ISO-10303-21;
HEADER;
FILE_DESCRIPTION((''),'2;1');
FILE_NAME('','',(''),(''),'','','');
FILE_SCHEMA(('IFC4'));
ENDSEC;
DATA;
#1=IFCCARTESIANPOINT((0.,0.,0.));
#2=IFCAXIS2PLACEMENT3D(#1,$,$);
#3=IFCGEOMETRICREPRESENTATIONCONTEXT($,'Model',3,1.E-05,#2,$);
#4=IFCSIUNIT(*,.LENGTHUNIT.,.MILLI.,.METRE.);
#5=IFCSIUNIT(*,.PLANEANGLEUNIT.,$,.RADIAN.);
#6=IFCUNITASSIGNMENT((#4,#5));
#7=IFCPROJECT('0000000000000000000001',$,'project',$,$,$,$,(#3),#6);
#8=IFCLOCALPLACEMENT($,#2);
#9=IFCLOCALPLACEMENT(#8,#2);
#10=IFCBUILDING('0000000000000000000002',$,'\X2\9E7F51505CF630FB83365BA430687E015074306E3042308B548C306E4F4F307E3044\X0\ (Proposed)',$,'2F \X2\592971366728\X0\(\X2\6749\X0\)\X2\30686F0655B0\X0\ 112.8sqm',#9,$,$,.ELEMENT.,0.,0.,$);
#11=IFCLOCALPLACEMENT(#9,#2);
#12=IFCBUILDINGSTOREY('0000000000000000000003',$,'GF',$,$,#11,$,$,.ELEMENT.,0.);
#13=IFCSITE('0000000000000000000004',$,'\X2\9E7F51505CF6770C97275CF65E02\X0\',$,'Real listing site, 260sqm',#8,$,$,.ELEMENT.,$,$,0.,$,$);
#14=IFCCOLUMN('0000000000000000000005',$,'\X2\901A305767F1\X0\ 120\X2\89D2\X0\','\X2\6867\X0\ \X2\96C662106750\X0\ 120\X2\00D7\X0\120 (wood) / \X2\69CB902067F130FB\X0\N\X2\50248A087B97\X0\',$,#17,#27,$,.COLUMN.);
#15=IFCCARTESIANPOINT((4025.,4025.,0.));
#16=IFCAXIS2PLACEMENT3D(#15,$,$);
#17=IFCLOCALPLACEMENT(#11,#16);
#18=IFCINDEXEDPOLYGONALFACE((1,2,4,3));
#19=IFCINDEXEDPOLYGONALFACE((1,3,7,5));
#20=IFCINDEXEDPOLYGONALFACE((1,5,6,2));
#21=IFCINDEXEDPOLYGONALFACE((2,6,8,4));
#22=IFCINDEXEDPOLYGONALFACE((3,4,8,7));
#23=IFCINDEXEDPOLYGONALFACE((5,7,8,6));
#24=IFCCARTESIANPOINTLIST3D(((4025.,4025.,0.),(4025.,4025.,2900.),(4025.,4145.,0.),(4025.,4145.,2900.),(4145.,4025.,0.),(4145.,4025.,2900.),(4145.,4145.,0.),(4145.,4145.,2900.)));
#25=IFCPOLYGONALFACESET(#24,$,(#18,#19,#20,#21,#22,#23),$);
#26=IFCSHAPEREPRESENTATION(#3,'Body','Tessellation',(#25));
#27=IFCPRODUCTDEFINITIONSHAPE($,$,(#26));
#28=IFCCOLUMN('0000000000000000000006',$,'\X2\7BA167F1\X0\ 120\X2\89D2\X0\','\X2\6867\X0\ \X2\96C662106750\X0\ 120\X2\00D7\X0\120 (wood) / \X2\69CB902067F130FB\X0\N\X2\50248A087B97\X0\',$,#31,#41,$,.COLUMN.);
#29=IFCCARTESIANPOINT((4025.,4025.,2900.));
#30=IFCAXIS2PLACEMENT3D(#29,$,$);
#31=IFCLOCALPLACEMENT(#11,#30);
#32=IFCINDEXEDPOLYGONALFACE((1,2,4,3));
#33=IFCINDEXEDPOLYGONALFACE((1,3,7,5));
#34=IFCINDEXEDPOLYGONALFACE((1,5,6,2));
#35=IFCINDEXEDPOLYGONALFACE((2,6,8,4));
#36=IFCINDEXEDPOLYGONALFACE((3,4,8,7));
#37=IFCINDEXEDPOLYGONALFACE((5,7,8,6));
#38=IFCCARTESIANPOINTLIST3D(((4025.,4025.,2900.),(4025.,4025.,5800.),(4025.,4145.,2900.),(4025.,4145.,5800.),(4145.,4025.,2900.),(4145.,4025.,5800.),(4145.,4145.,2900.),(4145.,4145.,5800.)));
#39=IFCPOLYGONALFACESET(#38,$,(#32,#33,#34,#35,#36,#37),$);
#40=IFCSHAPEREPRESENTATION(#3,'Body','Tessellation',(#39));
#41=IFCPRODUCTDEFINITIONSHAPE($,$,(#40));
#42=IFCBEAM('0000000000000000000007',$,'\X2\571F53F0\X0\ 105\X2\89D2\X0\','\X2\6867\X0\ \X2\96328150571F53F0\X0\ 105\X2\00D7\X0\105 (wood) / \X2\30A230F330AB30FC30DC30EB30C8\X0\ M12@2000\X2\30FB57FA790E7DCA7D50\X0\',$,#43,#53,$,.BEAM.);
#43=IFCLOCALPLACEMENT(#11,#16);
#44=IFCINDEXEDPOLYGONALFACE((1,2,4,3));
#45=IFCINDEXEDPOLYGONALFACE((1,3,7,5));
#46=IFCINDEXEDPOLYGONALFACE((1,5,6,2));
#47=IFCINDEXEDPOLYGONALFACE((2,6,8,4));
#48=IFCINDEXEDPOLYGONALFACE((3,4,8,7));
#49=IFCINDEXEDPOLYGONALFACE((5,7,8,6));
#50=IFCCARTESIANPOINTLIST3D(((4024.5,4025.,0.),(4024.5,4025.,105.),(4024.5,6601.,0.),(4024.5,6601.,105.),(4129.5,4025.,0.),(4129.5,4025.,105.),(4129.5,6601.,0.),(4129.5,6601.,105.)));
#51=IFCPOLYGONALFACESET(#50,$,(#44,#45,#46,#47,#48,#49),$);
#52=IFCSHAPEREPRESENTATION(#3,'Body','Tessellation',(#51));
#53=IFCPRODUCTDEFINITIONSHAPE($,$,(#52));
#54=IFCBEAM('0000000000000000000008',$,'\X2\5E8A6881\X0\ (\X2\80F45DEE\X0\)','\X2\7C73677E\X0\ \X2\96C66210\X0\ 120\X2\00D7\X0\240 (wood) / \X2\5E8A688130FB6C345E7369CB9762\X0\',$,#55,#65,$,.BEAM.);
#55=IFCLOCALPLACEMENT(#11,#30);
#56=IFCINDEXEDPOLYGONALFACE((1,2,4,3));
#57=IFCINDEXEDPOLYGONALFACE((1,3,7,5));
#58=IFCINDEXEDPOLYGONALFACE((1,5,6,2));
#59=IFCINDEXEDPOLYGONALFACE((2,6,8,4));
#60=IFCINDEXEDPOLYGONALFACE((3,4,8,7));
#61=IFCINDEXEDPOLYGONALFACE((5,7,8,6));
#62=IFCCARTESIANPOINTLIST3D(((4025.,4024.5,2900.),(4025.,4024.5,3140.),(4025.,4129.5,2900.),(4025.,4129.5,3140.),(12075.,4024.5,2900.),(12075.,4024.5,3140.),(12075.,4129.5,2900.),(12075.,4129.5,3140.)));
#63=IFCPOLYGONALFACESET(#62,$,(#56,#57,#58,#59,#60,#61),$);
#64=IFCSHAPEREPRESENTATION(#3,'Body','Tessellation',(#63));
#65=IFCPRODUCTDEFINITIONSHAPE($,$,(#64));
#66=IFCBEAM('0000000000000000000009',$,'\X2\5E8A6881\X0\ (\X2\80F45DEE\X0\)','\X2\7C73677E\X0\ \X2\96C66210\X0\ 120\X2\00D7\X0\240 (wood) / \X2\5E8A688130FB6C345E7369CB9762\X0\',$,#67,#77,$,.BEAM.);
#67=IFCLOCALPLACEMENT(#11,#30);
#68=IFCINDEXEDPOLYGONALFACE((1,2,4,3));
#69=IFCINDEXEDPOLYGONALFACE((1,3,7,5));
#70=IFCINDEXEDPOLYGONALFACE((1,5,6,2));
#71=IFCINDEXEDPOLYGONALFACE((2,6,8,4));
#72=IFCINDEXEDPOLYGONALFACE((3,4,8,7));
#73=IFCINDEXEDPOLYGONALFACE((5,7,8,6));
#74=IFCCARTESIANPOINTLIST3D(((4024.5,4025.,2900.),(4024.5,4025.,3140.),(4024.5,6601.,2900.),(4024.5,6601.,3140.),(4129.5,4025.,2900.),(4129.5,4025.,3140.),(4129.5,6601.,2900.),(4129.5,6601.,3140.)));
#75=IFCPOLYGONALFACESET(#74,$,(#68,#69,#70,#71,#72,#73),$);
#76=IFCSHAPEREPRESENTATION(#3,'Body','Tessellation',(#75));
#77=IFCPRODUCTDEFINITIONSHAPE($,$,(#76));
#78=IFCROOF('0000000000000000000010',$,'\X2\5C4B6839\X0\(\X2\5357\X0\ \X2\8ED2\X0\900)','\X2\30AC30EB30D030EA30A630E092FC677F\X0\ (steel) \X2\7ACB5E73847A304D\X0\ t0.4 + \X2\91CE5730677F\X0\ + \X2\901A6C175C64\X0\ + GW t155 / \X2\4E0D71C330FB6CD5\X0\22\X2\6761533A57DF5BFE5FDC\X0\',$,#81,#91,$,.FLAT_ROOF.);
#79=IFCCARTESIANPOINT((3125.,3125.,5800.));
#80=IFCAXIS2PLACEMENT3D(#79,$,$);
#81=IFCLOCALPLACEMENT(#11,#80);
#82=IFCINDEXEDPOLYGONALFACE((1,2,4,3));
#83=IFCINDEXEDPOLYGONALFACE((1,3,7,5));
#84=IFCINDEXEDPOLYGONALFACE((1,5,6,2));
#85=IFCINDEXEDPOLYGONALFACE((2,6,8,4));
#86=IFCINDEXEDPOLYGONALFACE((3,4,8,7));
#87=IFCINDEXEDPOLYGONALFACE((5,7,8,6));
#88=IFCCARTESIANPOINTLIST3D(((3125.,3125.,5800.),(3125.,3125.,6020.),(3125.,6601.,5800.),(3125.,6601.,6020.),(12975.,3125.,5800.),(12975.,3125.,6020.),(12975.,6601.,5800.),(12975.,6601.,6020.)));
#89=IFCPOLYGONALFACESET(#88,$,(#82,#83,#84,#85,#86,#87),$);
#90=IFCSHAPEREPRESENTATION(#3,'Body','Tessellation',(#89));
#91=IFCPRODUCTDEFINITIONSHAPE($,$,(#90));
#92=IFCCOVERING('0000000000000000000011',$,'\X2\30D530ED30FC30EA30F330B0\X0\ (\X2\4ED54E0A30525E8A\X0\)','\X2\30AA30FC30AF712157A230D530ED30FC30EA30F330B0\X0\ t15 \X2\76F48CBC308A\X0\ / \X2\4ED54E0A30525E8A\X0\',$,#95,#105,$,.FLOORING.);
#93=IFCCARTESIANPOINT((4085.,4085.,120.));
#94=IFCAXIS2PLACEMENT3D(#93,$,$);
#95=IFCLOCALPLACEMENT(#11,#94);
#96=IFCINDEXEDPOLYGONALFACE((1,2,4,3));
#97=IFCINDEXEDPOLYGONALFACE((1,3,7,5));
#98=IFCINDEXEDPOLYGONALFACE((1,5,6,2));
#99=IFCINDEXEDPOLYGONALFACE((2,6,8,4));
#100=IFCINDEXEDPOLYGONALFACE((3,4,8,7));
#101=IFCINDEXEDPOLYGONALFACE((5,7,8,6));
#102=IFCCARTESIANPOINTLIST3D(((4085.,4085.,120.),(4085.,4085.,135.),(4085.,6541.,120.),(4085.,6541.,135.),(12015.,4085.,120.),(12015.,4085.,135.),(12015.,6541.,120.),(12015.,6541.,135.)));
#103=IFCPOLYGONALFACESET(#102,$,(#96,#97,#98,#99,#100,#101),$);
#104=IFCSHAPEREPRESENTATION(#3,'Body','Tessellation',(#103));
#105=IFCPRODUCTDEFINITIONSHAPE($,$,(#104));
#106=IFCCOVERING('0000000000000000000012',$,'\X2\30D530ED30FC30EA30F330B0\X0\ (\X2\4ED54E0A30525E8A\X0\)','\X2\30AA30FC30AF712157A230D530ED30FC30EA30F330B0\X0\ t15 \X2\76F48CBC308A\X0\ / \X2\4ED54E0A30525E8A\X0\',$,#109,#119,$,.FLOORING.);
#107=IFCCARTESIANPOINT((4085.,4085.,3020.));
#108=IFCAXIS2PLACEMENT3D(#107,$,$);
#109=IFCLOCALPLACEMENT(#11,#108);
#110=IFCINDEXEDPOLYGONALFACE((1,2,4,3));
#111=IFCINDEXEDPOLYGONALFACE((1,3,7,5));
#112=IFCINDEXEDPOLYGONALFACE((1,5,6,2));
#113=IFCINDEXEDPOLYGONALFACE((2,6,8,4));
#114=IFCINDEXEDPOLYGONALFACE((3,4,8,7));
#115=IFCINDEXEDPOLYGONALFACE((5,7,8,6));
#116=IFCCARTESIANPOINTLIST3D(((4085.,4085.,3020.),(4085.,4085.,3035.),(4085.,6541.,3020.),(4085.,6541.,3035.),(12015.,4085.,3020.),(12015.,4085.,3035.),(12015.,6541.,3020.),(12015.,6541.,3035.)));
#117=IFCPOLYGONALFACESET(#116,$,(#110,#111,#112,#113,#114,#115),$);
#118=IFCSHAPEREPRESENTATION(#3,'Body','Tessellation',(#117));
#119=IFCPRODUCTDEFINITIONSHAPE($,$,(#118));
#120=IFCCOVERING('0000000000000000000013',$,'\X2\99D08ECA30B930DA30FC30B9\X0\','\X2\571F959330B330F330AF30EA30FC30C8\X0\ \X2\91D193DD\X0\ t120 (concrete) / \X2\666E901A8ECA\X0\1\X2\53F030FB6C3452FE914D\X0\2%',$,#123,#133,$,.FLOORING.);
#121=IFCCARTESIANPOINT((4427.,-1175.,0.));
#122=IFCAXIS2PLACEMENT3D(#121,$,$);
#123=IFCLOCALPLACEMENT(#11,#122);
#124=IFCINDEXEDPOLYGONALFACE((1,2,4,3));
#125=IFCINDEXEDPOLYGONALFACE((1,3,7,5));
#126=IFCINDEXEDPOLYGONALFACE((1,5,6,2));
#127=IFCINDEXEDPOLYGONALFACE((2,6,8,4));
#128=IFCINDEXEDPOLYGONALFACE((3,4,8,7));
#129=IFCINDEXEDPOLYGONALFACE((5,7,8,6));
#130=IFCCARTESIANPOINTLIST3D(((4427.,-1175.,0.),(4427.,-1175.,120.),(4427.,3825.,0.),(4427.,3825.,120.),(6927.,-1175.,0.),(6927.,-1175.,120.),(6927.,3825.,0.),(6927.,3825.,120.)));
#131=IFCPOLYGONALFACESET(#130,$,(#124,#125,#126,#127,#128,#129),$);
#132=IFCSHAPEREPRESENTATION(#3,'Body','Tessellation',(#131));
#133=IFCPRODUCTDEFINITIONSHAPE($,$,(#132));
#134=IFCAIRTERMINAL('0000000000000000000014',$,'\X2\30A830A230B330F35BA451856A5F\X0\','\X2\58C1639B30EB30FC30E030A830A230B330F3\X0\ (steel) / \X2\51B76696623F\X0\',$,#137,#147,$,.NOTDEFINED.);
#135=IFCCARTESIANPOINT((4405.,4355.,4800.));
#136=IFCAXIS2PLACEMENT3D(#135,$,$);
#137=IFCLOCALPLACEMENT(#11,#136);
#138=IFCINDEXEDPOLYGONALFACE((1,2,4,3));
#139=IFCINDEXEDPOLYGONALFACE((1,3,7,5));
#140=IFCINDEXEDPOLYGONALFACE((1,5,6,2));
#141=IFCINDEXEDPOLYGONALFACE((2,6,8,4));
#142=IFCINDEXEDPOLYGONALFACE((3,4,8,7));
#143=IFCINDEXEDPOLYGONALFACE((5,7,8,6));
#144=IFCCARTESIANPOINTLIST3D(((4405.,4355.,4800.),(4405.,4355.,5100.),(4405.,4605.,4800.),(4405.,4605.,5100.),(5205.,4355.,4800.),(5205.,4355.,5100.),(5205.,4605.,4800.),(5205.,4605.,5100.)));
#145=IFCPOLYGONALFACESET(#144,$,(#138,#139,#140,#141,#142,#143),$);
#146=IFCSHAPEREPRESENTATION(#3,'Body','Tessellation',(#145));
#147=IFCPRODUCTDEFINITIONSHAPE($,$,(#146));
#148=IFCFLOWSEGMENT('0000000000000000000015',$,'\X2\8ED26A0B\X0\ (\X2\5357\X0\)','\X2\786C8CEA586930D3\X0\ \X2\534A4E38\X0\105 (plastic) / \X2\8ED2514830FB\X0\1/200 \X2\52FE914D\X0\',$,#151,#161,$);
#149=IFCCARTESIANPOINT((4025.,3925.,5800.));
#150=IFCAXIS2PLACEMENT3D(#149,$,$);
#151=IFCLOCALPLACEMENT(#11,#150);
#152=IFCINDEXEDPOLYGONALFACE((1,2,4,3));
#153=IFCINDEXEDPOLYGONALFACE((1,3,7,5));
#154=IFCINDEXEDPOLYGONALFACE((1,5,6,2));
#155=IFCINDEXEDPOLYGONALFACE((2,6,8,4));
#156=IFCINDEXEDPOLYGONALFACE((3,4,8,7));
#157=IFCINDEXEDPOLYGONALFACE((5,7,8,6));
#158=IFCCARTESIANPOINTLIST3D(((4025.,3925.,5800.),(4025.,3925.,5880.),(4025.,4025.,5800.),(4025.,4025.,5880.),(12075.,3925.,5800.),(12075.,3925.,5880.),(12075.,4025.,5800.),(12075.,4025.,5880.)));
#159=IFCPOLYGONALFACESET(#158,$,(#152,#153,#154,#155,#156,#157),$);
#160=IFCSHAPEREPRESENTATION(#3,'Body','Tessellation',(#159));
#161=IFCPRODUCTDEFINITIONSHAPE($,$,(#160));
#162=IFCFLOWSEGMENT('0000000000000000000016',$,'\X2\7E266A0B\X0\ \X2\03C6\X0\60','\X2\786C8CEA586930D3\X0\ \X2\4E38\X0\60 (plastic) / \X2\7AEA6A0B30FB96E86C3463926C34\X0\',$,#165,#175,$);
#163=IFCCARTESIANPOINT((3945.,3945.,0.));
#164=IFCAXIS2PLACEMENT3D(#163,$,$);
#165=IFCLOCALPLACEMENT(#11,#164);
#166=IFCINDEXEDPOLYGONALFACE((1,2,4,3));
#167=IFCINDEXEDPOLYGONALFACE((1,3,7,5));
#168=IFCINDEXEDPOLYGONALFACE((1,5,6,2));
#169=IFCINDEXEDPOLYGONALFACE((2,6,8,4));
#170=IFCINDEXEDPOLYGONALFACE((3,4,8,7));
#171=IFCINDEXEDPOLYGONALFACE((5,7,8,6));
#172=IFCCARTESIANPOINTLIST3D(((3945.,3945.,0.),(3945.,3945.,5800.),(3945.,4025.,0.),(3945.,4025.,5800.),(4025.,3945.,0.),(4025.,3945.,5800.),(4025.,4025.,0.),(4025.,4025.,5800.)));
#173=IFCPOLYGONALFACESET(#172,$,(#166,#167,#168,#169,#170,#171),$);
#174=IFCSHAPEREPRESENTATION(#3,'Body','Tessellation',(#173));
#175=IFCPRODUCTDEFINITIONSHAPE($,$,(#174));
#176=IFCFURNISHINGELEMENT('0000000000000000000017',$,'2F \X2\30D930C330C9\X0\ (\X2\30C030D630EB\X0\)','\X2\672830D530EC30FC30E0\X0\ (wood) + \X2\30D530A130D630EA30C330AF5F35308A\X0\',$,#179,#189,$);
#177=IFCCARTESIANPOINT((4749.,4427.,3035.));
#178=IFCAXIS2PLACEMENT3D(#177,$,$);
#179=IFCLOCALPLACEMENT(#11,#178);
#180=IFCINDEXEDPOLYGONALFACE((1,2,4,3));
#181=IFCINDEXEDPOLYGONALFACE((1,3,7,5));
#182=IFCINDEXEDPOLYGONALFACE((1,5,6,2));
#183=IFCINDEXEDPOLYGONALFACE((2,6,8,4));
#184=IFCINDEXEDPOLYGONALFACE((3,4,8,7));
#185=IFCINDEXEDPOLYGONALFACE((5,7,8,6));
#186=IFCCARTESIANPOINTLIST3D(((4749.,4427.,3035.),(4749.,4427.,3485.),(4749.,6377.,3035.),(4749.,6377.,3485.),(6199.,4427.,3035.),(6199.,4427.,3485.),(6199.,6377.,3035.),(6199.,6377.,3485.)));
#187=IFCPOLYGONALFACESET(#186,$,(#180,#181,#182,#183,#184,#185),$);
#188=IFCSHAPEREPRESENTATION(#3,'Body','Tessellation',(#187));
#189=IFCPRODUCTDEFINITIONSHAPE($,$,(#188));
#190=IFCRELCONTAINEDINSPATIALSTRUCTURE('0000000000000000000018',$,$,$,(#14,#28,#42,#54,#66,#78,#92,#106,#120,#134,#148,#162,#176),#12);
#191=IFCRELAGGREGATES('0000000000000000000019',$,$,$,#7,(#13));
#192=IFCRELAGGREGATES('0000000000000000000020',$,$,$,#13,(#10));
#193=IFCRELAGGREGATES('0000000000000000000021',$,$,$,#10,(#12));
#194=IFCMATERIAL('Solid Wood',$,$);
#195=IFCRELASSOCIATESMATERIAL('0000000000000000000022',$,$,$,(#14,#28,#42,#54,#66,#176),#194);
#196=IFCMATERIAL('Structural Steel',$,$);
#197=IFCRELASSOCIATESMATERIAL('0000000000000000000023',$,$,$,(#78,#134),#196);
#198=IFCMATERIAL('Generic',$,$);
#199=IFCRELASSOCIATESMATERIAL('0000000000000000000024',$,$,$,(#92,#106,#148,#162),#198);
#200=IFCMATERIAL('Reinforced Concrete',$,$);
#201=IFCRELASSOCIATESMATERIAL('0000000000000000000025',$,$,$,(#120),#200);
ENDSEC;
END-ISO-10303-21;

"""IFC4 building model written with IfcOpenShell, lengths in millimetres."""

from ifc_helpers import new_model, si_unit, frame, frame_2d, origin, place, context, project, spatial, rectangle, extrude, material, element, save


model = new_model("IFC4")

# Units and contexts
model_context = context("Model", 3, precision=1e-05, world=origin())
ifc_project = project(units=[si_unit("LENGTHUNIT", "METRE", prefix="MILLI"), si_unit("PLANEANGLEUNIT", "RADIAN")], contexts=[model_context])

# Site, building, storey
site_placement = place(None, origin())
site = spatial("IfcSite", under=ifc_project, at=site_placement, Name="鹿児島県霧島市", ObjectType="Real listing site, 260sqm", CompositionType="ELEMENT", RefElevation=0.0)
building_placement = place(site_placement, origin())
building = spatial("IfcBuilding", under=site, at=building_placement, Name="鹿児島・茶室と縁側のある和の住まい (Proposed)", ObjectType="2F 天然木(杉)と漆喰 112.8sqm", CompositionType="ELEMENT", ElevationOfRefHeight=0.0, ElevationOfTerrain=0.0)
storey_placement = place(building_placement, origin())
storey = spatial("IfcBuildingStorey", under=building, at=storey_placement, Name="GF", CompositionType="ELEMENT", Elevation=0.0)

# Columns
ifc_material_1 = material(Name="Solid Wood")
column_1_placement = place(storey_placement, frame((4025.0, 4025.0, 0.0)))
element("IfcColumn", 1, at=column_1_placement, inside=storey, material=ifc_material_1, Name="通し柱 120角", Description="桧 集成材 120×120 (wood) / 構造柱・N値計算", PredefinedType="COLUMN", context=model_context, shape_type="SweptSolid", body=[
    extrude(rectangle(XDim=120.0, YDim=120.0, at=frame_2d((60.0, 60.0))), frame((4025.0, 4025.0, 0.0)), (0.0, 0.0, 1.0), 2900.0),
])
column_2_placement = place(storey_placement, frame((4025.0, 4025.0, 2900.0)))
element("IfcColumn", 2, at=column_2_placement, inside=storey, material=ifc_material_1, Name="管柱 120角", Description="桧 集成材 120×120 (wood) / 構造柱・N値計算", PredefinedType="COLUMN", context=model_context, shape_type="SweptSolid", body=[
    extrude(rectangle(XDim=120.0, YDim=120.0, at=frame_2d((60.0, 60.0))), frame((4025.0, 4025.0, 2900.0)), (0.0, 0.0, 1.0), 2900.0),
])

# Beams
beam_1_placement = place(storey_placement, frame((4025.0, 4025.0, 0.0)))
element("IfcBeam", 3, at=beam_1_placement, inside=storey, material=ifc_material_1, Name="土台 105角", Description="桧 防腐土台 105×105 (wood) / アンカーボルト M12@2000・基礎緊結", PredefinedType="BEAM", context=model_context, shape_type="SweptSolid", body=[
    extrude(rectangle(XDim=105.0, YDim=2576.0, at=frame_2d((52.0, 1288.0))), frame((4025.0, 4025.0, 0.0)), (0.0, 0.0, 1.0), 105.0),
])
beam_2_placement = place(storey_placement, frame((4025.0, 4025.0, 2900.0)))
element("IfcBeam", 4, at=beam_2_placement, inside=storey, material=ifc_material_1, Name="床梁 (胴差)", Description="米松 集成 120×240 (wood) / 床梁・水平構面", PredefinedType="BEAM", context=model_context, shape_type="SweptSolid", body=[
    extrude(rectangle(XDim=8050.0, YDim=105.0, at=frame_2d((4025.0, 52.0))), frame((4025.0, 4025.0, 2900.0)), (0.0, 0.0, 1.0), 240.0),
])
beam_3_placement = place(storey_placement, frame((4025.0, 4025.0, 2900.0)))
element("IfcBeam", 5, at=beam_3_placement, inside=storey, material=ifc_material_1, Name="床梁 (胴差)", Description="米松 集成 120×240 (wood) / 床梁・水平構面", PredefinedType="BEAM", context=model_context, shape_type="SweptSolid", body=[
    extrude(rectangle(XDim=105.0, YDim=2576.0, at=frame_2d((52.0, 1288.0))), frame((4025.0, 4025.0, 2900.0)), (0.0, 0.0, 1.0), 240.0),
])

# Shared definitions
ifc_material_2 = material(Name="Reinforced Concrete")

# Roof
ifc_material_3 = material(Name="Structural Steel")
for number, where, name in (
    (6, (3125.0, 3125.0, 5800.0), "屋根(南 軒900)"),
):
    element("IfcRoof", number, at=place(storey_placement, frame(where)), inside=storey, material=ifc_material_3, Name=name, Description="ガルバリウム鋼板 (steel) 立平葺き t0.4 + 野地板 + 通気層 + GW t155 / 不燃・法22条区域対応", PredefinedType="FLAT_ROOF", context=model_context, shape_type="SweptSolid", body=[
        extrude(rectangle(XDim=9850.0, YDim=3476.0, at=frame_2d((4925.0, 1738.0))), frame((3125.0, 3125.0, 5800.0)), (0.0, 0.0, 1.0), 220.0),
    ])

# Coverings
ifc_material_4 = material(Name="Generic")
covering_1_placement = place(storey_placement, frame((4085.0, 4085.0, 120.0)))
element("IfcCovering", 7, at=covering_1_placement, inside=storey, material=ifc_material_4, Name="フローリング (仕上げ床)", Description="オーク無垢フローリング t15 直貼り / 仕上げ床", PredefinedType="FLOORING", context=model_context, shape_type="SweptSolid", body=[
    extrude(rectangle(XDim=7930.0, YDim=2456.0, at=frame_2d((3965.0, 1228.0))), frame((4085.0, 4085.0, 120.0)), (0.0, 0.0, 1.0), 15.0),
])
covering_2_placement = place(storey_placement, frame((4085.0, 4085.0, 3020.0)))
element("IfcCovering", 8, at=covering_2_placement, inside=storey, material=ifc_material_4, Name="フローリング (仕上げ床)", Description="オーク無垢フローリング t15 直貼り / 仕上げ床", PredefinedType="FLOORING", context=model_context, shape_type="SweptSolid", body=[
    extrude(rectangle(XDim=7930.0, YDim=2456.0, at=frame_2d((3965.0, 1228.0))), frame((4085.0, 4085.0, 3020.0)), (0.0, 0.0, 1.0), 15.0),
])
covering_3_placement = place(storey_placement, frame((4427.0, -1175.0, 0.0)))
element("IfcCovering", 9, at=covering_3_placement, inside=storey, material=ifc_material_2, Name="駐車スペース", Description="土間コンクリート 金鏝 t120 (concrete) / 普通車1台・水勾配2%", PredefinedType="FLOORING", context=model_context, shape_type="SweptSolid", body=[
    extrude(rectangle(XDim=2500.0, YDim=5000.0, at=frame_2d((1250.0, 2500.0))), frame((4427.0, -1175.0, 0.0)), (0.0, 0.0, 1.0), 120.0),
])

# Air terminal
air_terminal_placement = place(storey_placement, frame((4405.0, 4355.0, 4800.0)))
element("IfcAirTerminal", 10, at=air_terminal_placement, inside=storey, material=ifc_material_3, Name="エアコン室内機", Description="壁掛ルームエアコン (steel) / 冷暖房", PredefinedType="NOTDEFINED", context=model_context, shape_type="SweptSolid", body=[
    extrude(rectangle(XDim=800.0, YDim=250.0, at=frame_2d((400.0, 125.0))), frame((4405.0, 4355.0, 4800.0)), (0.0, 0.0, 1.0), 300.0),
])

# Flow segments
flow_segment_1_placement = place(storey_placement, frame((4025.0, 3925.0, 5800.0)))
element("IfcFlowSegment", 11, at=flow_segment_1_placement, inside=storey, material=ifc_material_4, Name="軒樋 (南)", Description="硬質塩ビ 半丸105 (plastic) / 軒先・1/200 勾配", context=model_context, shape_type="SweptSolid", body=[
    extrude(rectangle(XDim=8050.0, YDim=100.0, at=frame_2d((4025.0, 50.0))), frame((4025.0, 3925.0, 5800.0)), (0.0, 0.0, 1.0), 80.0),
])
flow_segment_2_placement = place(storey_placement, frame((3945.0, 3945.0, 0.0)))
element("IfcFlowSegment", 12, at=flow_segment_2_placement, inside=storey, material=ifc_material_4, Name="縦樋 φ60", Description="硬質塩ビ 丸60 (plastic) / 竪樋・雨水排水", context=model_context, shape_type="SweptSolid", body=[
    extrude(rectangle(XDim=80.0, YDim=80.0, at=frame_2d((40.0, 40.0))), frame((3945.0, 3945.0, 0.0)), (0.0, 0.0, 1.0), 5800.0),
])

# Furnishing element
furnishing_placement = place(storey_placement, frame((4749.0, 4427.0, 3035.0)))
element("IfcFurnishingElement", 13, at=furnishing_placement, inside=storey, material=ifc_material_1, Name="2F ベッド (ダブル)", Description="木フレーム (wood) + ファブリック張り", context=model_context, shape_type="SweptSolid", body=[
    extrude(rectangle(XDim=1450.0, YDim=1950.0, at=frame_2d((725.0, 975.0))), frame((4749.0, 4427.0, 3035.0)), (0.0, 0.0, 1.0), 450.0),
])

save(model, "model.ifc")
